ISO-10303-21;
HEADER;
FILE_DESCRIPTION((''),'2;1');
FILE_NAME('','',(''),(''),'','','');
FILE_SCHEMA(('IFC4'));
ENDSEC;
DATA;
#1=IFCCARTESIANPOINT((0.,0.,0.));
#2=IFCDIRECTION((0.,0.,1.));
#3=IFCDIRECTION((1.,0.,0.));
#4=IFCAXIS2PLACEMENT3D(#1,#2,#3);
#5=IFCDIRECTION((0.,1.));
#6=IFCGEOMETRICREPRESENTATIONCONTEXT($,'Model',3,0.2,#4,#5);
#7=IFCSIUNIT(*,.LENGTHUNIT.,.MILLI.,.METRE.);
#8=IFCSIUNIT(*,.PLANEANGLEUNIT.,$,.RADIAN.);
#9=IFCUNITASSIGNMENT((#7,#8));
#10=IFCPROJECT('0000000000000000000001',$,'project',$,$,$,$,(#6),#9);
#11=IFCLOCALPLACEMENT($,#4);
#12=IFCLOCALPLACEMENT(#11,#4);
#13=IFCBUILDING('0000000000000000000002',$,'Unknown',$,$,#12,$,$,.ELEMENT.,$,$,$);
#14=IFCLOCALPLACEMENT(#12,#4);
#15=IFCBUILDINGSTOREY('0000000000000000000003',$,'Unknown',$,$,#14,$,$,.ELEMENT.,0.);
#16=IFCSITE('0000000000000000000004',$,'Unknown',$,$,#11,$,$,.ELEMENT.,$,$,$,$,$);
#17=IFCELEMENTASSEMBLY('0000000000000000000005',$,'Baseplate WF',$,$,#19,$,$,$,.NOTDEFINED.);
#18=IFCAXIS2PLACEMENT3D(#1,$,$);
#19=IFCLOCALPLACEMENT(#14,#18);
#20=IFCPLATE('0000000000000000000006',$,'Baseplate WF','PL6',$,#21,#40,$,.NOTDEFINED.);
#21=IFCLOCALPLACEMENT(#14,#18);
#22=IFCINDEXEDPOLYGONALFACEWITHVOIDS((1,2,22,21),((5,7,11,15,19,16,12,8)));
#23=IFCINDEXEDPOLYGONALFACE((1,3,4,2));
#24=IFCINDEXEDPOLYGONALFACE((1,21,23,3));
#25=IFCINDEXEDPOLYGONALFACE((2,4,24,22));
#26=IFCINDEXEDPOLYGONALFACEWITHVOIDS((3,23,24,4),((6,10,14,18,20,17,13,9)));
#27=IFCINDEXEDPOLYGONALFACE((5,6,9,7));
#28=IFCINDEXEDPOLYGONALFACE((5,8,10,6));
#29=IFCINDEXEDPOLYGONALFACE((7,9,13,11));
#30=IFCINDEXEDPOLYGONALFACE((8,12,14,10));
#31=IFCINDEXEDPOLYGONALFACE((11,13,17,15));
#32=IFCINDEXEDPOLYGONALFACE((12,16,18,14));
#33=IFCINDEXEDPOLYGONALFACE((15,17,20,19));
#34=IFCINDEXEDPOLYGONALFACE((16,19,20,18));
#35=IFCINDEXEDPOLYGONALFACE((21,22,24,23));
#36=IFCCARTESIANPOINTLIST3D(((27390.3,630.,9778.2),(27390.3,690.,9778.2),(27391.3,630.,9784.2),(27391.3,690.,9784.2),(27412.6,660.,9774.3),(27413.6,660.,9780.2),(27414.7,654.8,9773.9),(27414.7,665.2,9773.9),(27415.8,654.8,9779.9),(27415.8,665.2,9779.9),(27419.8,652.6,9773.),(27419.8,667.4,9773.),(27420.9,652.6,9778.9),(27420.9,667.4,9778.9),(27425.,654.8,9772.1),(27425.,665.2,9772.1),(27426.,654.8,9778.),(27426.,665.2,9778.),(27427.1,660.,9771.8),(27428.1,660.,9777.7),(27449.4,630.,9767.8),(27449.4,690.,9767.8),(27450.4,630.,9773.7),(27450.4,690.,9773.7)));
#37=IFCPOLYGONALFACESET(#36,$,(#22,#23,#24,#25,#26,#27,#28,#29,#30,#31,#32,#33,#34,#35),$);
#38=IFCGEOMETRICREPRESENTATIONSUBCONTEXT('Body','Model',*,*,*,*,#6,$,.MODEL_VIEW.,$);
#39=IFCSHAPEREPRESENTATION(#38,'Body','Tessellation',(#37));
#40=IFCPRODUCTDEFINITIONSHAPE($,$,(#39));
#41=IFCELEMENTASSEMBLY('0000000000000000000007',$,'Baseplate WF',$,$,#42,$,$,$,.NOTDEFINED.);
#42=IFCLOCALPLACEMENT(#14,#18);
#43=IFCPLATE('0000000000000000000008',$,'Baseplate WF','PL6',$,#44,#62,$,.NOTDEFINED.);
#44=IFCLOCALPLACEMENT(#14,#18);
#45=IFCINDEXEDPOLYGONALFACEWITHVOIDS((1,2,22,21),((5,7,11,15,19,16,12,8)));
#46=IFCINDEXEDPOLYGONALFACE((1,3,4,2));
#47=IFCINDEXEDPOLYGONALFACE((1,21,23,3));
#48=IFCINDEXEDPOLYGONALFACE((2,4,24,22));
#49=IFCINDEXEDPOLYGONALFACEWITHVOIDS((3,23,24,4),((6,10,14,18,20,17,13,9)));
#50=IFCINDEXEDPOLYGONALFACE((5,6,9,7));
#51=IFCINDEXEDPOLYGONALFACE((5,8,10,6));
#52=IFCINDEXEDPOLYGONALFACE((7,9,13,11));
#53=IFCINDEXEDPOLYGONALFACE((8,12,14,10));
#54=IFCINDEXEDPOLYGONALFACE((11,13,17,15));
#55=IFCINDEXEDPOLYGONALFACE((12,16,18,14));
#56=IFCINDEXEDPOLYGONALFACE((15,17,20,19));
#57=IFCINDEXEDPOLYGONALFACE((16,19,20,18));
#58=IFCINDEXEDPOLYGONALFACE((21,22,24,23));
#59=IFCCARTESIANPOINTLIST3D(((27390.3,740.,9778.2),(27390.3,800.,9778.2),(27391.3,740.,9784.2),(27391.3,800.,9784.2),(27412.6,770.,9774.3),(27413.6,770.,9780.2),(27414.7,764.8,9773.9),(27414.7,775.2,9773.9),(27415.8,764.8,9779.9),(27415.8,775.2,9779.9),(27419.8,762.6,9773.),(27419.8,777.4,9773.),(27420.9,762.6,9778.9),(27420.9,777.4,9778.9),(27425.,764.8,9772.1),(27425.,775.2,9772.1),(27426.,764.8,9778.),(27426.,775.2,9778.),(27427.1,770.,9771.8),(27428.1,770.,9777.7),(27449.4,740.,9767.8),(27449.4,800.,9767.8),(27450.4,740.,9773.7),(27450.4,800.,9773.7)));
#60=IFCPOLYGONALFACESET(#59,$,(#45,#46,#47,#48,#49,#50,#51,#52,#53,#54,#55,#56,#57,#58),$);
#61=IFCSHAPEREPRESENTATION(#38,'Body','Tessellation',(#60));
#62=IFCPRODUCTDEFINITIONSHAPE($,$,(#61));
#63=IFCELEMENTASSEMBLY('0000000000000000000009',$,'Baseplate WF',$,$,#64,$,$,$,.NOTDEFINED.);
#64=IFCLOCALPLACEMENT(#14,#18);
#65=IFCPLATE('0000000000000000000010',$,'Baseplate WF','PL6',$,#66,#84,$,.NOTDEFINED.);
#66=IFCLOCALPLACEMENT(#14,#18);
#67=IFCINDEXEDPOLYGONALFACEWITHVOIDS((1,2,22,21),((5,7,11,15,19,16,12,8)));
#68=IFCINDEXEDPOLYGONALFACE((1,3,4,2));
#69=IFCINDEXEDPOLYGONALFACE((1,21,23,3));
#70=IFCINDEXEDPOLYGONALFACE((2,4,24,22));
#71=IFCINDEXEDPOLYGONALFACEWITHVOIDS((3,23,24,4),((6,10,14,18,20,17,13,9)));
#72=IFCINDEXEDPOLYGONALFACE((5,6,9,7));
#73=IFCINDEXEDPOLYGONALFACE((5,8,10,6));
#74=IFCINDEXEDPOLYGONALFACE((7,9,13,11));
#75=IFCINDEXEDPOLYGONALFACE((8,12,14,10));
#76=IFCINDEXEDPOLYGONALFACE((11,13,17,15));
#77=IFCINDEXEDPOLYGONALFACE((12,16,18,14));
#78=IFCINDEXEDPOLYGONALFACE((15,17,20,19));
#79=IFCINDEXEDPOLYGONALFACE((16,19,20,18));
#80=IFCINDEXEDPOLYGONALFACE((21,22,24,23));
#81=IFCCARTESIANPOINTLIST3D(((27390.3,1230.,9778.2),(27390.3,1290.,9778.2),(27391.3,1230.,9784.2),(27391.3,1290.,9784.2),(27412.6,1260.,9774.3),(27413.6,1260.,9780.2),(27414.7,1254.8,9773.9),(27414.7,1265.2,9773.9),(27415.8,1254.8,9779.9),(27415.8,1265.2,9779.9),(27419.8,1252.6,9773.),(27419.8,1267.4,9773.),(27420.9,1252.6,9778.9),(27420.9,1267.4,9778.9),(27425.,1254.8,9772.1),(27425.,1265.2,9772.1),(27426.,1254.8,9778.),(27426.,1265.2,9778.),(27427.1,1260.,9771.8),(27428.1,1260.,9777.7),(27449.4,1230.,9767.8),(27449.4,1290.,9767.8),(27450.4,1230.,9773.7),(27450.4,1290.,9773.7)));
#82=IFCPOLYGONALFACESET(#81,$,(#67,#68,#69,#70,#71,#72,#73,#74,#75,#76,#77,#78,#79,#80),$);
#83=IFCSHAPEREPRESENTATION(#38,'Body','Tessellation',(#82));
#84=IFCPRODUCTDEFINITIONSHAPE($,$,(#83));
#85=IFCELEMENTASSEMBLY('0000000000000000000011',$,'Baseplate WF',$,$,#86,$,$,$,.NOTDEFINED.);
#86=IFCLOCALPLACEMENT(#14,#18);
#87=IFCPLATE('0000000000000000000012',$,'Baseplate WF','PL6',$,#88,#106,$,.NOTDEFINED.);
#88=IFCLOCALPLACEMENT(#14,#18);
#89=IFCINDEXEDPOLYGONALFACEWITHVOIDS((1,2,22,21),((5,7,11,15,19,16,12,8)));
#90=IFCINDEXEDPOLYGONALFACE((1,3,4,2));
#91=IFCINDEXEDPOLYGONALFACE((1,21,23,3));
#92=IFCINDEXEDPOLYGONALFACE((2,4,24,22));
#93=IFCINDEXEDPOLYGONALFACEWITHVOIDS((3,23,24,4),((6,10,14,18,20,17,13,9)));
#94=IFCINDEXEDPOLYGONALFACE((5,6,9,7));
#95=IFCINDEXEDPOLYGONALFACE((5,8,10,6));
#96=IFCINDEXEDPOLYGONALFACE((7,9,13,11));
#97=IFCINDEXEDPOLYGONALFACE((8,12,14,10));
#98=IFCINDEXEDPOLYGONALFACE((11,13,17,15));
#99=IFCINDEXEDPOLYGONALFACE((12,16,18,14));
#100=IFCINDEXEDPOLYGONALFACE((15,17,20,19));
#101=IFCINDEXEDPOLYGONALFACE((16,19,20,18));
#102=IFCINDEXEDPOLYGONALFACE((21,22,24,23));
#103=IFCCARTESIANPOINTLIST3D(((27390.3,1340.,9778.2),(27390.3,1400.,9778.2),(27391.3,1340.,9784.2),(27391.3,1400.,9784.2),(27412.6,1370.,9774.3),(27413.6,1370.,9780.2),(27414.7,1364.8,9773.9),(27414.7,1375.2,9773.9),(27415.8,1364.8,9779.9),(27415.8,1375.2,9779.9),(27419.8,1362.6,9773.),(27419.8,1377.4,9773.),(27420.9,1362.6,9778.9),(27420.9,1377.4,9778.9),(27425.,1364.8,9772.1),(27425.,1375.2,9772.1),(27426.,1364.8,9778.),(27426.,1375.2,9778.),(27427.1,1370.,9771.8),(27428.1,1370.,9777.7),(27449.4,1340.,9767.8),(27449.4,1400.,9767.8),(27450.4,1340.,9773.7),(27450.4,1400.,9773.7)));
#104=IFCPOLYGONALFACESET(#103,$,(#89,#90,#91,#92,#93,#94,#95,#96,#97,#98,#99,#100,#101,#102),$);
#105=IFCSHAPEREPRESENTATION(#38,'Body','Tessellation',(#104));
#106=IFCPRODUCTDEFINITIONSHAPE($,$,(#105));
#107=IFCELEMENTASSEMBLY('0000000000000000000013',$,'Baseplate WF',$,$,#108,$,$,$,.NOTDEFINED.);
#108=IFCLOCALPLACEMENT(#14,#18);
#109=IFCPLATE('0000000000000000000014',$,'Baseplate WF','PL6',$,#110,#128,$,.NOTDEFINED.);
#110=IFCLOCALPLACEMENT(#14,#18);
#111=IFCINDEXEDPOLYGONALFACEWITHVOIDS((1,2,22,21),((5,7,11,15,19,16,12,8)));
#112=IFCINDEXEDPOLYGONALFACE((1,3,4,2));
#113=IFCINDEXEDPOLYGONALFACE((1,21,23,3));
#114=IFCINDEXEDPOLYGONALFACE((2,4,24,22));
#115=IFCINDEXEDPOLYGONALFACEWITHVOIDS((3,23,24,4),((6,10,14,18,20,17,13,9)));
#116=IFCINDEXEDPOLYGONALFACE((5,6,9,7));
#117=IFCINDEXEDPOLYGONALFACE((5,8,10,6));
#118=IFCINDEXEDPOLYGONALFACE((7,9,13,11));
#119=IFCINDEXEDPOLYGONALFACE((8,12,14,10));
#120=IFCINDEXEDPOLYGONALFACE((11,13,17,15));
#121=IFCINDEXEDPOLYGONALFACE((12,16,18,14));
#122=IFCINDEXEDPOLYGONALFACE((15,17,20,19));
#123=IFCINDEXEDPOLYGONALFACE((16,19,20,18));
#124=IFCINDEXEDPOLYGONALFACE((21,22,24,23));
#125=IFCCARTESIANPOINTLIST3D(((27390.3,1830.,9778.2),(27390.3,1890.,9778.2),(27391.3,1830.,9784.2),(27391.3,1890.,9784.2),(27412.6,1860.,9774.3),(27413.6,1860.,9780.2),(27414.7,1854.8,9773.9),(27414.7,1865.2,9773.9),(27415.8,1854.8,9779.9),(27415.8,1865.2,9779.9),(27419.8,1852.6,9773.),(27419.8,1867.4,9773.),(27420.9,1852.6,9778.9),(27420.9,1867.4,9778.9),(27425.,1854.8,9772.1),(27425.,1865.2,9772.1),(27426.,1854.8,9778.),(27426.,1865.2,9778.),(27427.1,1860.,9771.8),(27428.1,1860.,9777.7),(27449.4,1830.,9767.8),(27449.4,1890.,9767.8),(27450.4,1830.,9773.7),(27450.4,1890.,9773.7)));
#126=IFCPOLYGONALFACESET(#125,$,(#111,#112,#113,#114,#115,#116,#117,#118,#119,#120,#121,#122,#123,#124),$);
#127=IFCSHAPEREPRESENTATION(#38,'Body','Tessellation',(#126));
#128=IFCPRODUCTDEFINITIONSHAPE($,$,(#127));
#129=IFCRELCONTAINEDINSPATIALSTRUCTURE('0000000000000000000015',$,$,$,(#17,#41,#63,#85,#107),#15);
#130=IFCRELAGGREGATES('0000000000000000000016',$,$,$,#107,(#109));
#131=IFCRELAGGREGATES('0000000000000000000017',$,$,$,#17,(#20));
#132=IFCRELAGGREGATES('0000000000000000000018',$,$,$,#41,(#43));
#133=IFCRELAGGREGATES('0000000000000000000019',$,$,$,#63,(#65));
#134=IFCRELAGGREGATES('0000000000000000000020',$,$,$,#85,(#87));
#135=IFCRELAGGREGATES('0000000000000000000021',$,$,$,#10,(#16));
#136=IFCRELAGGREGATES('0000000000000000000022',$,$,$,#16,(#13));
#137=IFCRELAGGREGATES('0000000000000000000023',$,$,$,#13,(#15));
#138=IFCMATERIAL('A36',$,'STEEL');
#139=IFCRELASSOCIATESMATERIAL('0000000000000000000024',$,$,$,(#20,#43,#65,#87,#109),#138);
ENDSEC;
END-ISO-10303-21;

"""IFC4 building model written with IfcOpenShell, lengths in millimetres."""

from ifc_helpers import new_model, si_unit, direction, frame, origin_with_axes, place, context, subcontext, project, spatial, line, indexed_curve, outline, extrude, material, element, aggregate, save


model = new_model("IFC4")

# Units and contexts
model_context = context("Model", 3, precision=0.2, world=origin_with_axes(), true_north=direction((0.0, 1.0)))
body_context = subcontext(model_context, "Body", "Model", "MODEL_VIEW")
ifc_project = project(units=[si_unit("LENGTHUNIT", "METRE", prefix="MILLI"), si_unit("PLANEANGLEUNIT", "RADIAN")], contexts=[model_context])

# Site, building, storey
site_placement = place(None, origin_with_axes())
site = spatial("IfcSite", under=ifc_project, at=site_placement, Name="Unknown", CompositionType="ELEMENT")
building_placement = place(site_placement, origin_with_axes())
building = spatial("IfcBuilding", under=site, at=building_placement, Name="Unknown", CompositionType="ELEMENT")
storey_placement = place(building_placement, origin_with_axes())
storey = spatial("IfcBuildingStorey", under=building, at=storey_placement, Name="Unknown", CompositionType="ELEMENT", Elevation=0.0)

# Element assemblies, plates, voiding features
assembly_1_placement = place(storey_placement, frame((27449.9, 690.0, 9770.8), z_axis=(-0.173648, 0.0, -0.984808), x_axis=(0.0, -1.0, 0.0)))
assembly_1 = element("IfcElementAssembly", 1, at=assembly_1_placement, inside=storey, Name="Baseplate WF", PredefinedType="NOTDEFINED")
ifc_material_1 = material(Name="A36", Category="STEEL")
plate_1_placement = place(assembly_1_placement, origin_with_axes())
plate_1 = element("IfcPlate", 2, at=plate_1_placement, material=ifc_material_1, Name="Baseplate WF", Description="PL6", PredefinedType="NOTDEFINED", context=body_context, shape_type="SolidModel", body=[
    extrude(outline(indexed_curve([(0.0, 0.0), (60.0, 0.0), (60.0, 60.0), (0.0, 60.0)], segments=[line(1, 2, 3, 4, 1)])), frame((0.0, 0.0, 3.0), z_axis=(0.0, 0.0, 1.0), x_axis=(1.0, 0.0, 0.0)), (0.0, 0.0, -1.0), 6.0),
])
voiding_feature_1_placement = place(plate_1_placement, frame((30.0, 30.0, -3.5), z_axis=(-1.0, 0.0, 0.0), x_axis=(0.0, 0.0, 1.0)))
element("IfcVoidingFeature", 3, at=voiding_feature_1_placement, cuts=plate_1, Name="BEAM", PredefinedType="HOLE", context=body_context, shape_type="SolidModel", body=[
    extrude(outline(indexed_curve([(7.4, 0.0), (5.2, 5.2), (0.0, 7.4), (-5.2, 5.2), (-7.4, 0.0), (-5.2, -5.2), (0.0, -7.4), (5.2, -5.2)], segments=[line(1, 2, 3, 4, 5, 6, 7, 8, 1)])), frame((0.0, 0.0, 0.0), z_axis=(-1.0, 0.0, 0.0), x_axis=(0.0, 0.0, 1.0)), (0.0, 0.0, -1.0), 7.0),
])
voiding_feature_2_placement = place(plate_1_placement, frame((-80.0, 30.0, -3.5), z_axis=(-1.0, 0.0, 0.0), x_axis=(0.0, 0.0, 1.0)))
element("IfcVoidingFeature", 4, at=voiding_feature_2_placement, cuts=plate_1, Name="BEAM", PredefinedType="HOLE", context=body_context, shape_type="SolidModel", body=[
    extrude(outline(indexed_curve([(7.4, 0.0), (5.2, 5.2), (0.0, 7.4), (-5.2, 5.2), (-7.4, 0.0), (-5.2, -5.2), (0.0, -7.4), (5.2, -5.2)], segments=[line(1, 2, 3, 4, 5, 6, 7, 8, 1)])), frame((0.0, 0.0, 0.0), z_axis=(-1.0, 0.0, 0.0), x_axis=(0.0, 0.0, 1.0)), (0.0, 0.0, -1.0), 7.0),
])
assembly_2_placement = place(storey_placement, frame((27449.9, 800.0, 9770.8), z_axis=(-0.173648, 0.0, -0.984808), x_axis=(0.0, -1.0, 0.0)))
assembly_2 = element("IfcElementAssembly", 5, at=assembly_2_placement, inside=storey, Name="Baseplate WF", PredefinedType="NOTDEFINED")
plate_2_placement = place(assembly_2_placement, origin_with_axes())
plate_2 = element("IfcPlate", 6, at=plate_2_placement, material=ifc_material_1, Name="Baseplate WF", Description="PL6", PredefinedType="NOTDEFINED", context=body_context, shape_type="SolidModel", body=[
    extrude(outline(indexed_curve([(0.0, 0.0), (60.0, 0.0), (60.0, 60.0), (0.0, 60.0)], segments=[line(1, 2, 3, 4, 1)])), frame((0.0, 0.0, 3.0), z_axis=(0.0, 0.0, 1.0), x_axis=(1.0, 0.0, 0.0)), (0.0, 0.0, -1.0), 6.0),
])
voiding_feature_3_placement = place(plate_2_placement, frame((140.0, 30.0, -3.5), z_axis=(-1.0, 0.0, 0.0), x_axis=(0.0, 0.0, 1.0)))
element("IfcVoidingFeature", 7, at=voiding_feature_3_placement, cuts=plate_2, Name="BEAM", PredefinedType="HOLE", context=body_context, shape_type="SolidModel", body=[
    extrude(outline(indexed_curve([(7.4, 0.0), (5.2, 5.2), (0.0, 7.4), (-5.2, 5.2), (-7.4, 0.0), (-5.2, -5.2), (0.0, -7.4), (5.2, -5.2)], segments=[line(1, 2, 3, 4, 5, 6, 7, 8, 1)])), frame((0.0, 0.0, 0.0), z_axis=(-1.0, 0.0, 0.0), x_axis=(0.0, 0.0, 1.0)), (0.0, 0.0, -1.0), 7.0),
])
voiding_feature_4_placement = place(plate_2_placement, frame((30.0, 30.0, -3.5), z_axis=(-1.0, 0.0, 0.0), x_axis=(0.0, 0.0, 1.0)))
element("IfcVoidingFeature", 8, at=voiding_feature_4_placement, cuts=plate_2, Name="BEAM", PredefinedType="HOLE", context=body_context, shape_type="SolidModel", body=[
    extrude(outline(indexed_curve([(7.4, 0.0), (5.2, 5.2), (0.0, 7.4), (-5.2, 5.2), (-7.4, 0.0), (-5.2, -5.2), (0.0, -7.4), (5.2, -5.2)], segments=[line(1, 2, 3, 4, 5, 6, 7, 8, 1)])), frame((0.0, 0.0, 0.0), z_axis=(-1.0, 0.0, 0.0), x_axis=(0.0, 0.0, 1.0)), (0.0, 0.0, -1.0), 7.0),
])
assembly_3_placement = place(storey_placement, frame((27449.9, 1290.0, 9770.8), z_axis=(-0.173648, 0.0, -0.984808), x_axis=(0.0, -1.0, 0.0)))
assembly_3 = element("IfcElementAssembly", 9, at=assembly_3_placement, inside=storey, Name="Baseplate WF", PredefinedType="NOTDEFINED")
plate_3_placement = place(assembly_3_placement, origin_with_axes())
plate_3 = element("IfcPlate", 10, at=plate_3_placement, material=ifc_material_1, Name="Baseplate WF", Description="PL6", PredefinedType="NOTDEFINED", context=body_context, shape_type="SolidModel", body=[
    extrude(outline(indexed_curve([(0.0, 0.0), (60.0, 0.0), (60.0, 60.0), (0.0, 60.0)], segments=[line(1, 2, 3, 4, 1)])), frame((0.0, 0.0, 3.0), z_axis=(0.0, 0.0, 1.0), x_axis=(1.0, 0.0, 0.0)), (0.0, 0.0, -1.0), 6.0),
])
voiding_feature_5_placement = place(plate_3_placement, frame((30.0, 30.0, -3.5), z_axis=(-1.0, 0.0, 0.0), x_axis=(0.0, 0.0, 1.0)))
element("IfcVoidingFeature", 11, at=voiding_feature_5_placement, cuts=plate_3, Name="BEAM", PredefinedType="HOLE", context=body_context, shape_type="SolidModel", body=[
    extrude(outline(indexed_curve([(7.4, 0.0), (5.2, 5.2), (0.0, 7.4), (-5.2, 5.2), (-7.4, 0.0), (-5.2, -5.2), (0.0, -7.4), (5.2, -5.2)], segments=[line(1, 2, 3, 4, 5, 6, 7, 8, 1)])), frame((0.0, 0.0, 0.0), z_axis=(-1.0, 0.0, 0.0), x_axis=(0.0, 0.0, 1.0)), (0.0, 0.0, -1.0), 7.0),
])
voiding_feature_6_placement = place(plate_3_placement, frame((-80.0, 30.0, -3.5), z_axis=(-1.0, 0.0, 0.0), x_axis=(0.0, 0.0, 1.0)))
element("IfcVoidingFeature", 12, at=voiding_feature_6_placement, cuts=plate_3, Name="BEAM", PredefinedType="HOLE", context=body_context, shape_type="SolidModel", body=[
    extrude(outline(indexed_curve([(7.4, 0.0), (5.2, 5.2), (0.0, 7.4), (-5.2, 5.2), (-7.4, 0.0), (-5.2, -5.2), (0.0, -7.4), (5.2, -5.2)], segments=[line(1, 2, 3, 4, 5, 6, 7, 8, 1)])), frame((0.0, 0.0, 0.0), z_axis=(-1.0, 0.0, 0.0), x_axis=(0.0, 0.0, 1.0)), (0.0, 0.0, -1.0), 7.0),
])
assembly_4_placement = place(storey_placement, frame((27449.9, 1400.0, 9770.8), z_axis=(-0.173648, 0.0, -0.984808), x_axis=(0.0, -1.0, 0.0)))
assembly_4 = element("IfcElementAssembly", 13, at=assembly_4_placement, inside=storey, Name="Baseplate WF", PredefinedType="NOTDEFINED")
plate_4_placement = place(assembly_4_placement, origin_with_axes())
plate_4 = element("IfcPlate", 14, at=plate_4_placement, material=ifc_material_1, Name="Baseplate WF", Description="PL6", PredefinedType="NOTDEFINED", context=body_context, shape_type="SolidModel", body=[
    extrude(outline(indexed_curve([(0.0, 0.0), (60.0, 0.0), (60.0, 60.0), (0.0, 60.0)], segments=[line(1, 2, 3, 4, 1)])), frame((0.0, 0.0, 3.0), z_axis=(0.0, 0.0, 1.0), x_axis=(1.0, 0.0, 0.0)), (0.0, 0.0, -1.0), 6.0),
])
voiding_feature_7_placement = place(plate_4_placement, frame((140.0, 30.0, -3.5), z_axis=(-1.0, 0.0, 0.0), x_axis=(0.0, 0.0, 1.0)))
element("IfcVoidingFeature", 15, at=voiding_feature_7_placement, cuts=plate_4, Name="BEAM", PredefinedType="HOLE", context=body_context, shape_type="SolidModel", body=[
    extrude(outline(indexed_curve([(7.4, 0.0), (5.2, 5.2), (0.0, 7.4), (-5.2, 5.2), (-7.4, 0.0), (-5.2, -5.2), (0.0, -7.4), (5.2, -5.2)], segments=[line(1, 2, 3, 4, 5, 6, 7, 8, 1)])), frame((0.0, 0.0, 0.0), z_axis=(-1.0, 0.0, 0.0), x_axis=(0.0, 0.0, 1.0)), (0.0, 0.0, -1.0), 7.0),
])
voiding_feature_8_placement = place(plate_4_placement, frame((30.0, 30.0, -3.5), z_axis=(-1.0, 0.0, 0.0), x_axis=(0.0, 0.0, 1.0)))
element("IfcVoidingFeature", 16, at=voiding_feature_8_placement, cuts=plate_4, Name="BEAM", PredefinedType="HOLE", context=body_context, shape_type="SolidModel", body=[
    extrude(outline(indexed_curve([(7.4, 0.0), (5.2, 5.2), (0.0, 7.4), (-5.2, 5.2), (-7.4, 0.0), (-5.2, -5.2), (0.0, -7.4), (5.2, -5.2)], segments=[line(1, 2, 3, 4, 5, 6, 7, 8, 1)])), frame((0.0, 0.0, 0.0), z_axis=(-1.0, 0.0, 0.0), x_axis=(0.0, 0.0, 1.0)), (0.0, 0.0, -1.0), 7.0),
])
assembly_5_placement = place(storey_placement, frame((27449.9, 1890.0, 9770.8), z_axis=(-0.173648, 0.0, -0.984808), x_axis=(0.0, -1.0, 0.0)))
assembly_5 = element("IfcElementAssembly", 17, at=assembly_5_placement, inside=storey, Name="Baseplate WF", PredefinedType="NOTDEFINED")
plate_5_placement = place(assembly_5_placement, origin_with_axes())
plate_5 = element("IfcPlate", 18, at=plate_5_placement, material=ifc_material_1, Name="Baseplate WF", Description="PL6", PredefinedType="NOTDEFINED", context=body_context, shape_type="SolidModel", body=[
    extrude(outline(indexed_curve([(0.0, 0.0), (60.0, 0.0), (60.0, 60.0), (0.0, 60.0)], segments=[line(1, 2, 3, 4, 1)])), frame((0.0, 0.0, 3.0), z_axis=(0.0, 0.0, 1.0), x_axis=(1.0, 0.0, 0.0)), (0.0, 0.0, -1.0), 6.0),
])
voiding_feature_9_placement = place(plate_5_placement, frame((30.0, 30.0, -3.5), z_axis=(-1.0, 0.0, 0.0), x_axis=(0.0, 0.0, 1.0)))
element("IfcVoidingFeature", 19, at=voiding_feature_9_placement, cuts=plate_5, Name="BEAM", PredefinedType="HOLE", context=body_context, shape_type="SolidModel", body=[
    extrude(outline(indexed_curve([(7.4, 0.0), (5.2, 5.2), (0.0, 7.4), (-5.2, 5.2), (-7.4, 0.0), (-5.2, -5.2), (0.0, -7.4), (5.2, -5.2)], segments=[line(1, 2, 3, 4, 5, 6, 7, 8, 1)])), frame((0.0, 0.0, 0.0), z_axis=(-1.0, 0.0, 0.0), x_axis=(0.0, 0.0, 1.0)), (0.0, 0.0, -1.0), 7.0),
])
voiding_feature_10_placement = place(plate_5_placement, frame((-80.0, 30.0, -3.5), z_axis=(-1.0, 0.0, 0.0), x_axis=(0.0, 0.0, 1.0)))
element("IfcVoidingFeature", 20, at=voiding_feature_10_placement, cuts=plate_5, Name="BEAM", PredefinedType="HOLE", context=body_context, shape_type="SolidModel", body=[
    extrude(outline(indexed_curve([(7.4, 0.0), (5.2, 5.2), (0.0, 7.4), (-5.2, 5.2), (-7.4, 0.0), (-5.2, -5.2), (0.0, -7.4), (5.2, -5.2)], segments=[line(1, 2, 3, 4, 5, 6, 7, 8, 1)])), frame((0.0, 0.0, 0.0), z_axis=(-1.0, 0.0, 0.0), x_axis=(0.0, 0.0, 1.0)), (0.0, 0.0, -1.0), 7.0),
])
aggregate(assembly_5, [plate_5])

aggregate(assembly_1, [plate_1])
aggregate(assembly_2, [plate_2])
aggregate(assembly_3, [plate_3])
aggregate(assembly_4, [plate_4])

save(model, "model.ifc")
